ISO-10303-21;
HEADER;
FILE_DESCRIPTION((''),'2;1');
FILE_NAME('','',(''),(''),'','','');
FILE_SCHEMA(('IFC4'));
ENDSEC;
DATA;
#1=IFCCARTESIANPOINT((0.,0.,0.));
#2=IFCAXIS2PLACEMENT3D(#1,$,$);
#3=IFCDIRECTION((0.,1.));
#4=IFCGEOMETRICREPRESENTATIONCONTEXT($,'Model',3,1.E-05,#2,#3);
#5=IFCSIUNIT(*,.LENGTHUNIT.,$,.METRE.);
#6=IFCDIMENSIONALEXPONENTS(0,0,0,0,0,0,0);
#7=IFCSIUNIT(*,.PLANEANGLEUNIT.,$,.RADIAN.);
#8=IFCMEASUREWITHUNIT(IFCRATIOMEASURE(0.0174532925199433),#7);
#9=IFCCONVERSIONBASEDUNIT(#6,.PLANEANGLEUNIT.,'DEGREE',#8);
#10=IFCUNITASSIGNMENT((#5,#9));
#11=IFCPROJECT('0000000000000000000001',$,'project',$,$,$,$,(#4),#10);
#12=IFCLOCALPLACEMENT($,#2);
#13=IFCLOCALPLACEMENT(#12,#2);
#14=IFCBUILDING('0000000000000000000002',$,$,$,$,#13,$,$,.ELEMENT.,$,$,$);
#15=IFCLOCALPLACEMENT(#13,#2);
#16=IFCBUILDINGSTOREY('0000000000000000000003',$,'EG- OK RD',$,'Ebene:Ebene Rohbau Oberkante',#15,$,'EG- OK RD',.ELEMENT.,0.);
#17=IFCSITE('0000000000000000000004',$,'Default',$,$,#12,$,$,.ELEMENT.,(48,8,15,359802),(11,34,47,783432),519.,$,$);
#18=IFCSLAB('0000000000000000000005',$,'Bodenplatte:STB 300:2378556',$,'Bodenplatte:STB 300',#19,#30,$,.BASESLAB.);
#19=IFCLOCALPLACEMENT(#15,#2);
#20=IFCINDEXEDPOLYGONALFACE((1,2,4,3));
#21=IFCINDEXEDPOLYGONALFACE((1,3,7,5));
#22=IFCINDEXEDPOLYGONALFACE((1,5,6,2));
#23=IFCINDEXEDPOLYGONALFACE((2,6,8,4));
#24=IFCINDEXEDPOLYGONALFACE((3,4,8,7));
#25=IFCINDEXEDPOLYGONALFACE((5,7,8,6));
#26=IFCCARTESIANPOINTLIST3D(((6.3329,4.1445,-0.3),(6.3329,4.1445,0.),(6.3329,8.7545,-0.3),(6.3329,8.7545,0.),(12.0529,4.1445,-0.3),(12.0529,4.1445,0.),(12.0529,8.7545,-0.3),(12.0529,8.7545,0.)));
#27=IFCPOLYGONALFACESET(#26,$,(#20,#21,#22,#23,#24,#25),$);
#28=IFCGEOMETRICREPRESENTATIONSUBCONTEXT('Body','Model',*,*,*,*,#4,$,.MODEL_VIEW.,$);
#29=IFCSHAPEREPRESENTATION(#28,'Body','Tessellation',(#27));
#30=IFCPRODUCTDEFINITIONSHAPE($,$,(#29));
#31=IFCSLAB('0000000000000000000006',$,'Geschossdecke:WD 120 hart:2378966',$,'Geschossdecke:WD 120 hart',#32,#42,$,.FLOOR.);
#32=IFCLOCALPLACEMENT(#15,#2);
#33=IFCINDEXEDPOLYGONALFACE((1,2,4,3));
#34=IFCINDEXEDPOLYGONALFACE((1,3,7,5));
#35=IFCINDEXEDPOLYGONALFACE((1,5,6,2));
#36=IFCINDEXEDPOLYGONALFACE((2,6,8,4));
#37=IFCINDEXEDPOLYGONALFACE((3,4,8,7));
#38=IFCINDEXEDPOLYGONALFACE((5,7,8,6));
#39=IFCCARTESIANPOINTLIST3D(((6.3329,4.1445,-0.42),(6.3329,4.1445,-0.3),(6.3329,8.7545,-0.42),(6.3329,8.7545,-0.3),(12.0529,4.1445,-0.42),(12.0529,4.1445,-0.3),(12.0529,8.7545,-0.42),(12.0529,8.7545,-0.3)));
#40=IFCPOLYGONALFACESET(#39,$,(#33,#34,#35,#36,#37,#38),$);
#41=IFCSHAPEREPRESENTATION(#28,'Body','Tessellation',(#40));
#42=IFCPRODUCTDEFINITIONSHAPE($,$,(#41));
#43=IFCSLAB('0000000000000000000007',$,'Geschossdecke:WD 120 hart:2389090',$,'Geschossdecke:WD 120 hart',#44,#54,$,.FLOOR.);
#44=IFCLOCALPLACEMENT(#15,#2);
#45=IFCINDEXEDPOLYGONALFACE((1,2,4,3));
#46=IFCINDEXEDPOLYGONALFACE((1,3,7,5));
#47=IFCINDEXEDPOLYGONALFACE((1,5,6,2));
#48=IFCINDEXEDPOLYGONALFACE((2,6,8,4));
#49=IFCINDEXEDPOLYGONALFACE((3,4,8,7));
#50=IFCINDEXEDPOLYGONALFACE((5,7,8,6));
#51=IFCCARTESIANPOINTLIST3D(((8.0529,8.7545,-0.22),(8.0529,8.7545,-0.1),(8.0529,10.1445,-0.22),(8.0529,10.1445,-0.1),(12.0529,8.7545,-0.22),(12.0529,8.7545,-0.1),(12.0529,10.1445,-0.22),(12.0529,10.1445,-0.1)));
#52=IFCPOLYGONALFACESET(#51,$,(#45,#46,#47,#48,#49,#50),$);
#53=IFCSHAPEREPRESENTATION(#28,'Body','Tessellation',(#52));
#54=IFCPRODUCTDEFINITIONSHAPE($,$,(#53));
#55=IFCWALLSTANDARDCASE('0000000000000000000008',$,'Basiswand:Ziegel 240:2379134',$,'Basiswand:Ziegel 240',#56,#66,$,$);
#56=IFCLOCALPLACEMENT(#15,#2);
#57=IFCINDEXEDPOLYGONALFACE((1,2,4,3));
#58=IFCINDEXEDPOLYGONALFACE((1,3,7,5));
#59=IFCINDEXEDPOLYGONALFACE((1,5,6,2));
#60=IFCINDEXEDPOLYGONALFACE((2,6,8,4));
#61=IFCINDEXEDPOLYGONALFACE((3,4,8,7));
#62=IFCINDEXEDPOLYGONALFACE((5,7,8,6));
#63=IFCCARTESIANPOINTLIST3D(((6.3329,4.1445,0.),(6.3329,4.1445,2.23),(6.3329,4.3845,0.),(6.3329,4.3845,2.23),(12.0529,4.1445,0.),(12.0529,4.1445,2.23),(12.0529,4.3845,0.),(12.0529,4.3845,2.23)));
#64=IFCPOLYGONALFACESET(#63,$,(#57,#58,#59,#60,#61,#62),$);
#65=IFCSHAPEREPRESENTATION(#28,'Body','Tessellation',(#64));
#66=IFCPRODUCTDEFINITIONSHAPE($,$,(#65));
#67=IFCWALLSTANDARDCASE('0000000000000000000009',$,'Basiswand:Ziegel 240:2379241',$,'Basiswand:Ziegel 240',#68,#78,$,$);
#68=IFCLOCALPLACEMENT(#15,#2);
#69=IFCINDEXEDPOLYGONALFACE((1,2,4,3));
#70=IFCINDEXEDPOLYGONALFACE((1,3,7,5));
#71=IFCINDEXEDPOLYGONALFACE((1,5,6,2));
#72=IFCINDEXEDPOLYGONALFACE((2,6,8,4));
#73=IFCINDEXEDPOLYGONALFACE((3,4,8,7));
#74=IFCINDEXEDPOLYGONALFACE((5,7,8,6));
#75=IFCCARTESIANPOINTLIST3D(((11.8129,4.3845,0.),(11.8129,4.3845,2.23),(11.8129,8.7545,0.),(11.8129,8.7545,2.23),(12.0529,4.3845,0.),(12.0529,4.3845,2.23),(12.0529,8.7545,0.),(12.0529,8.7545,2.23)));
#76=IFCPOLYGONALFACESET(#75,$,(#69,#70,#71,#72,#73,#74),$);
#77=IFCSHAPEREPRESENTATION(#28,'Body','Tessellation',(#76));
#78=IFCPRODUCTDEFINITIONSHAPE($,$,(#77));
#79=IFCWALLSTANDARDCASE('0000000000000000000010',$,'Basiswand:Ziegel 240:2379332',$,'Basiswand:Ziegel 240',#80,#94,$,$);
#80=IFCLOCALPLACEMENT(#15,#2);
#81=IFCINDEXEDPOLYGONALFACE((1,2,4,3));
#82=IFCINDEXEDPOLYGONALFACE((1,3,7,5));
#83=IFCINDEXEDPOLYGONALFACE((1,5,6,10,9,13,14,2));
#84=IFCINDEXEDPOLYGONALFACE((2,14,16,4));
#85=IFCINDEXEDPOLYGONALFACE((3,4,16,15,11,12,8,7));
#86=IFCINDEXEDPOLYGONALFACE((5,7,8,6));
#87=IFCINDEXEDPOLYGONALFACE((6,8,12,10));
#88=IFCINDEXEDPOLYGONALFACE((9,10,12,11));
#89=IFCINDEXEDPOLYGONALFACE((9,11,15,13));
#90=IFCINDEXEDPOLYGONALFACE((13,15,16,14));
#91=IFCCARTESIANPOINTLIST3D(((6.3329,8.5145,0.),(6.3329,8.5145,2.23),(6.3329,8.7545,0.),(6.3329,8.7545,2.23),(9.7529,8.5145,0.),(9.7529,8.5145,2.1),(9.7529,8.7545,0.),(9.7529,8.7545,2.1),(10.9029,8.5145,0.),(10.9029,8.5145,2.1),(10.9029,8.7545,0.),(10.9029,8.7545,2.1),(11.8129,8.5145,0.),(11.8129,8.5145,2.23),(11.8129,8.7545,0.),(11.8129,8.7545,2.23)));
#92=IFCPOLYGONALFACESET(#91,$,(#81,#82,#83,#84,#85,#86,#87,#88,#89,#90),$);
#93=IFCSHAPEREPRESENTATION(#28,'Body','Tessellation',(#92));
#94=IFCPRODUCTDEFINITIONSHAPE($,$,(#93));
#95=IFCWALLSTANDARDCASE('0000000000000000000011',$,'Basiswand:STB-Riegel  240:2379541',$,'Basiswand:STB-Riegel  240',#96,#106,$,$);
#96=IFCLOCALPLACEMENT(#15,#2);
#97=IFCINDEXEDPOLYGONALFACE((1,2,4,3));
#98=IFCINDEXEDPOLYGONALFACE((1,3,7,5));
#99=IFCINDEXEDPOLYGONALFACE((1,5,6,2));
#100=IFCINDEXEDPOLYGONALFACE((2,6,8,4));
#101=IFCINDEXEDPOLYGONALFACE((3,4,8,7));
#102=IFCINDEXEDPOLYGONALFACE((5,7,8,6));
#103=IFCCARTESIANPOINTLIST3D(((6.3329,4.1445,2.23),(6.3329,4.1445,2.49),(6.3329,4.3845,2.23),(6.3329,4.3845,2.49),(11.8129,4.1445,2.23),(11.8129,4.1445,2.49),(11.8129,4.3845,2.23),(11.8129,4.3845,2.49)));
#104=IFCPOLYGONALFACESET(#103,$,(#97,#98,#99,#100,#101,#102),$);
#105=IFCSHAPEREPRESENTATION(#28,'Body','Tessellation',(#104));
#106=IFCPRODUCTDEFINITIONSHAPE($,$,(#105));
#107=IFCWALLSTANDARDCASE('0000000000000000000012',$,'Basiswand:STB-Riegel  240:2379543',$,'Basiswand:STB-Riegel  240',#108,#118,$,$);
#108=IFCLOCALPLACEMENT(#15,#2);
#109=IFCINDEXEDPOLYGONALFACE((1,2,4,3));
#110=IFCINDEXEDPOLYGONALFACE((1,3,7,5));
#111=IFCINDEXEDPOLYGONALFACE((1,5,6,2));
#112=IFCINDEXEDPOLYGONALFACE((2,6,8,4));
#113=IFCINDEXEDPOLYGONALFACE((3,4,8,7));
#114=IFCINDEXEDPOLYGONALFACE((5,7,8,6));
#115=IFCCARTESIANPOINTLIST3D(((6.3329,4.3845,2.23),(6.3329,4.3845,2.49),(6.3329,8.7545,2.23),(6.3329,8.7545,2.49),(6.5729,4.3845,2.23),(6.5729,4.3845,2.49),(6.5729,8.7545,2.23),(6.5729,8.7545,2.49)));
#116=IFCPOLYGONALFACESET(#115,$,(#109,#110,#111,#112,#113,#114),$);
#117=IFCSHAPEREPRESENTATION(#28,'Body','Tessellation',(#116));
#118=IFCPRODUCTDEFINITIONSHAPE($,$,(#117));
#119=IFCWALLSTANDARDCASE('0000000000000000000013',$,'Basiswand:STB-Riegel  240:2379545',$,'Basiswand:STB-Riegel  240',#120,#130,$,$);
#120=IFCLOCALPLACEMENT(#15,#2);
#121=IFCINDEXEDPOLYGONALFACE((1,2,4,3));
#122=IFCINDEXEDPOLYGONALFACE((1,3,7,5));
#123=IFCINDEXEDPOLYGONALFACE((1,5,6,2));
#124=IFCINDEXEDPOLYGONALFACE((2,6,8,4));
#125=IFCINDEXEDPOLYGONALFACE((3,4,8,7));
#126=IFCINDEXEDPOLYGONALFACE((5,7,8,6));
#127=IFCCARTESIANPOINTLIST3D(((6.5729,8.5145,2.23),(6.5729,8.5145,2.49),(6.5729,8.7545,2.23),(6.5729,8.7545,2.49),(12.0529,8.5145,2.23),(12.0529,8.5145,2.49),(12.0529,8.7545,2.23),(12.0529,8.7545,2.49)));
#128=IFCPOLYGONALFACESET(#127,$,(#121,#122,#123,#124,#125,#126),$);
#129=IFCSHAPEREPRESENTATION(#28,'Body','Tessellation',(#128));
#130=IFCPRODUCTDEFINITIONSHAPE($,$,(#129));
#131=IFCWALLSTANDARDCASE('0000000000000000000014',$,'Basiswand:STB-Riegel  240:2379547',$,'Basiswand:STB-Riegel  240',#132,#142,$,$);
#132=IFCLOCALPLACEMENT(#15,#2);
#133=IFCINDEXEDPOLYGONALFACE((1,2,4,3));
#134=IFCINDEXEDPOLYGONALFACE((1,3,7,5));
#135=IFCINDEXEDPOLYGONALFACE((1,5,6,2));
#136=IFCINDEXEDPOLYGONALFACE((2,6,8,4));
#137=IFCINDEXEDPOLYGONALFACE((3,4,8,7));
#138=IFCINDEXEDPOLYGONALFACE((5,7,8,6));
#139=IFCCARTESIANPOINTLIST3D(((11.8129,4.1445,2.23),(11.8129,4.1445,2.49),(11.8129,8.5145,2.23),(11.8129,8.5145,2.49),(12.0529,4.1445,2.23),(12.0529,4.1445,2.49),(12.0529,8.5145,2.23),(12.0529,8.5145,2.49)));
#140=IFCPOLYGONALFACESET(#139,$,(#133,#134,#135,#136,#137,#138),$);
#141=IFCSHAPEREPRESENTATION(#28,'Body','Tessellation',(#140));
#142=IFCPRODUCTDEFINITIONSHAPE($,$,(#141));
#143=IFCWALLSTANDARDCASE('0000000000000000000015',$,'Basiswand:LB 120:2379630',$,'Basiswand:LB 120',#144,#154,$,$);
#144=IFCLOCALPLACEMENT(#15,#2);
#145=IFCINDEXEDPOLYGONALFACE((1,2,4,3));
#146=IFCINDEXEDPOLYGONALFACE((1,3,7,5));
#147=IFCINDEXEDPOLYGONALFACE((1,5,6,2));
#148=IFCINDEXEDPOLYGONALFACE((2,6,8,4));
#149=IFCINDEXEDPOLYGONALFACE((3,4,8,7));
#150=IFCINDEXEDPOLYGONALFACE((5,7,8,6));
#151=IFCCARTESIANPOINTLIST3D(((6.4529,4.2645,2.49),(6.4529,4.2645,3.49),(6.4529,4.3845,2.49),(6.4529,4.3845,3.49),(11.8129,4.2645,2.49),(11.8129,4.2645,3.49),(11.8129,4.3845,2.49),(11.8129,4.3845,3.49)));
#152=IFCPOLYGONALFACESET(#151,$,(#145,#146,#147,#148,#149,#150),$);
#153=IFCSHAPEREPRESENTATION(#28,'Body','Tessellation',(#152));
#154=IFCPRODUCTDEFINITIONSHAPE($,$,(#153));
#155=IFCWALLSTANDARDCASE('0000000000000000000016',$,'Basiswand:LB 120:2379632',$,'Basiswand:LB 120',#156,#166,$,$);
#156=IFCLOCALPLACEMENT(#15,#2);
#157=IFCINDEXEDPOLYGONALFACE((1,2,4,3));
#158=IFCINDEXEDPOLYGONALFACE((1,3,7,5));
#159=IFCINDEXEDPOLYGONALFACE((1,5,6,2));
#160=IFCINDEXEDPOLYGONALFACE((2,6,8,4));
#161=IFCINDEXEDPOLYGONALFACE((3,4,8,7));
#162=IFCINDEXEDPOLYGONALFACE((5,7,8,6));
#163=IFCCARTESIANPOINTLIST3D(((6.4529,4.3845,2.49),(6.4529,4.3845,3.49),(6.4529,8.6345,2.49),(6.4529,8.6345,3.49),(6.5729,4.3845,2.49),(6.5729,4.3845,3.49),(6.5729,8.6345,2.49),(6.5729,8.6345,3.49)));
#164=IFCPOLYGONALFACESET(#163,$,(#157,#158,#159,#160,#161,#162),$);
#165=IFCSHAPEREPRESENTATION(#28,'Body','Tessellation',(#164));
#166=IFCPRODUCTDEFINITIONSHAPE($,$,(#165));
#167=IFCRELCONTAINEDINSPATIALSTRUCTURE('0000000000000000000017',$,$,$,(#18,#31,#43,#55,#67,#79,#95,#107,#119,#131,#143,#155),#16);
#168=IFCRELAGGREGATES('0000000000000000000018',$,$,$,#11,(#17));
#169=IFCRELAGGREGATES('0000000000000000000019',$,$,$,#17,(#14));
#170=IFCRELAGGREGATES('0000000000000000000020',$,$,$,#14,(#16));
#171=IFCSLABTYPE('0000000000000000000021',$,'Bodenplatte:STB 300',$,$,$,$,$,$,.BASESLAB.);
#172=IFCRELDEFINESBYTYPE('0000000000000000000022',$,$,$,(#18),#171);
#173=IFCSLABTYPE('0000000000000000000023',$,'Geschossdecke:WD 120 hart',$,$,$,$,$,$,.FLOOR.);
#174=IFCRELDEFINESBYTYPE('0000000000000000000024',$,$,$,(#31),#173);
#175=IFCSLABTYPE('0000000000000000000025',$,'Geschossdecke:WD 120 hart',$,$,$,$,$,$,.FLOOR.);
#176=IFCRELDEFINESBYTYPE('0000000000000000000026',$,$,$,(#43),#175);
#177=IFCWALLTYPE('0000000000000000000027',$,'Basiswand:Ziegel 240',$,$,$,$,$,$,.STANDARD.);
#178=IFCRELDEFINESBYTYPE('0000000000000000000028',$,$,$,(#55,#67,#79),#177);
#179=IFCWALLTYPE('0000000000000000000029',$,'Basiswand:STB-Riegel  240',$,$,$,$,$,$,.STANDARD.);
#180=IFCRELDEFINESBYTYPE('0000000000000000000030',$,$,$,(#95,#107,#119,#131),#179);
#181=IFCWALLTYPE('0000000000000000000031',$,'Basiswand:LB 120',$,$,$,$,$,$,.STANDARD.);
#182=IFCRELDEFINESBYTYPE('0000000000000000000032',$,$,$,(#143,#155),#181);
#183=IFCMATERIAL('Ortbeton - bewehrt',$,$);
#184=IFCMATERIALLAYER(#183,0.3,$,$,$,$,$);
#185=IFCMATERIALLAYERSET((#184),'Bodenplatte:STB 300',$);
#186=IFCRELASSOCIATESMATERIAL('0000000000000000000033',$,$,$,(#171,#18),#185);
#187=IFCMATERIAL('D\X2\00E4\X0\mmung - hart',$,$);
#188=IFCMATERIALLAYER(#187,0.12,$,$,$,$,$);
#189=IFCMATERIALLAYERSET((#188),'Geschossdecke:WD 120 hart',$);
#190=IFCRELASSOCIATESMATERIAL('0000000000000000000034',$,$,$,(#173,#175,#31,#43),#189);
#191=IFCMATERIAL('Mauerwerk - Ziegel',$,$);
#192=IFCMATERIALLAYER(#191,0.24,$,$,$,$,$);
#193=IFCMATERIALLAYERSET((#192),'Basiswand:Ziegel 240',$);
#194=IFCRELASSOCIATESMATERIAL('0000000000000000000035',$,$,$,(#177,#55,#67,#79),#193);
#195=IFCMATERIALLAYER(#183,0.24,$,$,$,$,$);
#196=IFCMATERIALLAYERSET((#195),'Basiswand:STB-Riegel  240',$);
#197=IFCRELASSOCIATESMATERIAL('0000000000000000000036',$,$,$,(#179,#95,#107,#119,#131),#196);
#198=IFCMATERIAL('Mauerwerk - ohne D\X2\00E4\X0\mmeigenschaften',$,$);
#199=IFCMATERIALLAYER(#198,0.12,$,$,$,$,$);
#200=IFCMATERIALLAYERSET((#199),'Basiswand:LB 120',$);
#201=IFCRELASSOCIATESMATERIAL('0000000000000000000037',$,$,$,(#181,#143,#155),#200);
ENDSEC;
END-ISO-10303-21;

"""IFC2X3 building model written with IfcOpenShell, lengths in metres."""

from ifc_helpers import new_model, entity, si_unit, converted_unit, direction, frame, frame_2d, origin, place, context, subcontext, project, spatial, rectangle, extrude, material, layer, layer_set, layer_usage, type_object, element, save


model = new_model("IFC2X3")

# Units and contexts
model_context = context("Model", 3, precision=1e-05, world=origin(), true_north=direction((0.0, 1.0)))
body_context = subcontext(model_context, "Body", "Model", "MODEL_VIEW")
ifc_project = project(units=[si_unit("LENGTHUNIT", "METRE"), converted_unit("PLANEANGLEUNIT", "DEGREE", entity("IfcRatioMeasure", 0.0174532925199433), si_unit("PLANEANGLEUNIT", "RADIAN"), dimensions=[0, 0, 0, 0, 0, 0, 0])], contexts=[model_context])

# Site, building, storey
site_placement = place(None, origin())
site = spatial("IfcSite", under=ifc_project, at=site_placement, Name="Default", CompositionType="ELEMENT", RefLatitude=(48, 8, 15, 359802), RefLongitude=(11, 34, 47, 783432), RefElevation=519.0)
building_placement = place(site_placement, origin())
building = spatial("IfcBuilding", under=site, at=building_placement, CompositionType="ELEMENT")
storey_placement = place(building_placement, origin())
storey = spatial("IfcBuildingStorey", under=building, at=storey_placement, Name="EG- OK RD", ObjectType="Ebene:Ebene Rohbau Oberkante", LongName="EG- OK RD", CompositionType="ELEMENT", Elevation=0.0)

# Slabs
ifc_material_1 = material(Name="Ortbeton - bewehrt")
ifc_layer_1 = layer(ifc_material_1, 0.3)
ifc_layer_set_1 = layer_set([ifc_layer_1], Name="Bodenplatte:STB 300")
ifc_layer_usage_1 = layer_usage(ifc_layer_set_1, "AXIS3", "POSITIVE", 0.0)
slab_type_1 = type_object("IfcSlabType", Name="Bodenplatte:STB 300", PredefinedType="BASESLAB", material=ifc_layer_set_1)
slab_1_placement = place(storey_placement, origin())
element("IfcSlab", 1, at=slab_1_placement, inside=storey, type_object=slab_type_1, material=ifc_layer_usage_1, Name="Bodenplatte:STB 300:2378556", ObjectType="Bodenplatte:STB 300", PredefinedType="BASESLAB", context=body_context, shape_type="SweptSolid", body=[
    extrude(rectangle(XDim=4.61, YDim=5.72, at=frame_2d((0.0, 0.0), x_axis=(1.0, 0.0))), frame((9.1929, 6.4495, 0.0), z_axis=(0.0, 0.0, -1.0), x_axis=(0.0, 1.0, 0.0)), (0.0, 0.0, 1.0), 0.3),
])
ifc_material_2 = material(Name="Dämmung - hart")
ifc_layer_2 = layer(ifc_material_2, 0.12)
ifc_layer_set_2 = layer_set([ifc_layer_2], Name="Geschossdecke:WD 120 hart")
ifc_layer_usage_2 = layer_usage(ifc_layer_set_2, "AXIS3", "POSITIVE", 0.0)
slab_type_2 = type_object("IfcSlabType", Name="Geschossdecke:WD 120 hart", PredefinedType="FLOOR", material=ifc_layer_set_2)
slab_2_placement = place(storey_placement, origin())
element("IfcSlab", 2, at=slab_2_placement, inside=storey, type_object=slab_type_2, material=ifc_layer_usage_2, Name="Geschossdecke:WD 120 hart:2378966", ObjectType="Geschossdecke:WD 120 hart", PredefinedType="FLOOR", context=body_context, shape_type="SweptSolid", body=[
    extrude(rectangle(XDim=4.61, YDim=5.72, at=frame_2d((0.0, 0.0), x_axis=(1.0, 0.0))), frame((9.1929, 6.4495, -0.3), z_axis=(0.0, 0.0, -1.0), x_axis=(0.0, 1.0, 0.0)), (0.0, 0.0, 1.0), 0.12),
])
ifc_layer_usage_3 = layer_usage(ifc_layer_set_2, "AXIS3", "POSITIVE", 0.0)
slab_type_3 = type_object("IfcSlabType", Name="Geschossdecke:WD 120 hart", PredefinedType="FLOOR", material=ifc_layer_set_2)
slab_3_placement = place(storey_placement, origin())
element("IfcSlab", 3, at=slab_3_placement, inside=storey, type_object=slab_type_3, material=ifc_layer_usage_3, Name="Geschossdecke:WD 120 hart:2389090", ObjectType="Geschossdecke:WD 120 hart", PredefinedType="FLOOR", context=body_context, shape_type="SweptSolid", body=[
    extrude(rectangle(XDim=1.39, YDim=4.0, at=frame_2d((0.0, 0.0), x_axis=(1.0, 0.0))), frame((10.0529, 9.4495, -0.1), z_axis=(0.0, 0.0, -1.0), x_axis=(0.0, 1.0, 0.0)), (0.0, 0.0, 1.0), 0.12),
])

# Walls
ifc_material_3 = material(Name="Mauerwerk - Ziegel")
ifc_layer_3 = layer(ifc_material_3, 0.24)
ifc_layer_set_3 = layer_set([ifc_layer_3], Name="Basiswand:Ziegel 240")
ifc_layer_usage_4 = layer_usage(ifc_layer_set_3, "AXIS2", "POSITIVE", -0.12)
wall_type_1 = type_object("IfcWallType", Name="Basiswand:Ziegel 240", PredefinedType="STANDARD", material=ifc_layer_set_3)
wall_1_placement = place(storey_placement, frame((6.3329, 4.2645, 0.0)))
element("IfcWallStandardCase", 4, at=wall_1_placement, inside=storey, type_object=wall_type_1, material=ifc_layer_usage_4, Name="Basiswand:Ziegel 240:2379134", ObjectType="Basiswand:Ziegel 240", context=body_context, shape_type="SweptSolid", body=[
    extrude(rectangle(XDim=5.72, YDim=0.24, at=frame_2d((2.86, 0.0), x_axis=(-1.0, 0.0))), origin(), (0.0, 0.0, 1.0), 2.23),
])
ifc_layer_usage_5 = layer_usage(ifc_layer_set_3, "AXIS2", "POSITIVE", -0.12)
wall_2_placement = place(storey_placement, frame((11.9329, 4.3845, 0.0), z_axis=(0.0, 0.0, 1.0), x_axis=(0.0, 1.0, 0.0)))
element("IfcWallStandardCase", 5, at=wall_2_placement, inside=storey, type_object=wall_type_1, material=ifc_layer_usage_5, Name="Basiswand:Ziegel 240:2379241", ObjectType="Basiswand:Ziegel 240", context=body_context, shape_type="SweptSolid", body=[
    extrude(rectangle(XDim=4.37, YDim=0.24, at=frame_2d((2.185, 0.0), x_axis=(-1.0, 0.0))), origin(), (0.0, 0.0, 1.0), 2.23),
])

# Wall, opening
ifc_layer_usage_6 = layer_usage(ifc_layer_set_3, "AXIS2", "POSITIVE", -0.12)
wall_3_placement = place(storey_placement, frame((11.8129, 8.6345, 0.0), z_axis=(0.0, 0.0, 1.0), x_axis=(-1.0, 0.0, 0.0)))
wall_3 = element("IfcWallStandardCase", 6, at=wall_3_placement, inside=storey, type_object=wall_type_1, material=ifc_layer_usage_6, Name="Basiswand:Ziegel 240:2379332", ObjectType="Basiswand:Ziegel 240", context=body_context, shape_type="SweptSolid", body=[
    extrude(rectangle(XDim=5.48, YDim=0.24, at=frame_2d((2.74, 0.0), x_axis=(-1.0, 0.0))), origin(), (0.0, 0.0, 1.0), 2.23),
])
opening_1_placement = place(wall_3_placement, frame((0.91, -0.12, 0.0)))
element("IfcOpeningElement", 7, at=opening_1_placement, cuts=wall_3, ObjectType="Opening", context=body_context, shape_type="SweptSolid", body=[
    extrude(rectangle(XDim=2.1, YDim=1.15, at=frame_2d((1.05, 0.575), x_axis=(-1.0, 0.0))), frame((0.0, 0.0, 0.0), z_axis=(0.0, 1.0, 0.0), x_axis=(0.0, 0.0, 1.0)), (0.0, 0.0, 1.0), 0.24),
])

# Walls
ifc_layer_4 = layer(ifc_material_1, 0.24)
ifc_layer_set_4 = layer_set([ifc_layer_4], Name="Basiswand:STB-Riegel  240")
ifc_layer_usage_7 = layer_usage(ifc_layer_set_4, "AXIS2", "NEGATIVE", 0.12)
wall_type_2 = type_object("IfcWallType", Name="Basiswand:STB-Riegel  240", PredefinedType="STANDARD", material=ifc_layer_set_4)
wall_4_placement = place(storey_placement, frame((6.3329, 4.2645, 2.23)))
element("IfcWallStandardCase", 8, at=wall_4_placement, inside=storey, type_object=wall_type_2, material=ifc_layer_usage_7, Name="Basiswand:STB-Riegel  240:2379541", ObjectType="Basiswand:STB-Riegel  240", context=body_context, shape_type="SweptSolid", body=[
    extrude(rectangle(XDim=5.48, YDim=0.24, at=frame_2d((2.74, 0.0), x_axis=(-1.0, 0.0))), origin(), (0.0, 0.0, 1.0), 0.26),
])
ifc_layer_usage_8 = layer_usage(ifc_layer_set_4, "AXIS2", "NEGATIVE", 0.12)
wall_5_placement = place(storey_placement, frame((6.4529, 8.7545, 2.23), z_axis=(0.0, 0.0, 1.0), x_axis=(0.0, -1.0, 0.0)))
element("IfcWallStandardCase", 9, at=wall_5_placement, inside=storey, type_object=wall_type_2, material=ifc_layer_usage_8, Name="Basiswand:STB-Riegel  240:2379543", ObjectType="Basiswand:STB-Riegel  240", context=body_context, shape_type="SweptSolid", body=[
    extrude(rectangle(XDim=4.37, YDim=0.24, at=frame_2d((2.185, 0.0), x_axis=(-1.0, 0.0))), origin(), (0.0, 0.0, 1.0), 0.26),
])
ifc_layer_usage_9 = layer_usage(ifc_layer_set_4, "AXIS2", "NEGATIVE", 0.12)
wall_6_placement = place(storey_placement, frame((12.0529, 8.6345, 2.23), z_axis=(0.0, 0.0, 1.0), x_axis=(-1.0, 0.0, 0.0)))
element("IfcWallStandardCase", 10, at=wall_6_placement, inside=storey, type_object=wall_type_2, material=ifc_layer_usage_9, Name="Basiswand:STB-Riegel  240:2379545", ObjectType="Basiswand:STB-Riegel  240", context=body_context, shape_type="SweptSolid", body=[
    extrude(rectangle(XDim=5.48, YDim=0.24, at=frame_2d((2.74, 0.0), x_axis=(-1.0, 0.0))), origin(), (0.0, 0.0, 1.0), 0.26),
])
ifc_layer_usage_10 = layer_usage(ifc_layer_set_4, "AXIS2", "NEGATIVE", 0.12)
wall_7_placement = place(storey_placement, frame((11.9329, 4.1445, 2.23), z_axis=(0.0, 0.0, 1.0), x_axis=(0.0, 1.0, 0.0)))
element("IfcWallStandardCase", 11, at=wall_7_placement, inside=storey, type_object=wall_type_2, material=ifc_layer_usage_10, Name="Basiswand:STB-Riegel  240:2379547", ObjectType="Basiswand:STB-Riegel  240", context=body_context, shape_type="SweptSolid", body=[
    extrude(rectangle(XDim=4.37, YDim=0.24, at=frame_2d((2.185, 0.0), x_axis=(-1.0, 0.0))), origin(), (0.0, 0.0, 1.0), 0.26),
])
ifc_material_4 = material(Name="Mauerwerk - ohne Dämmeigenschaften")
ifc_layer_5 = layer(ifc_material_4, 0.12)
ifc_layer_set_5 = layer_set([ifc_layer_5], Name="Basiswand:LB 120")
ifc_layer_usage_11 = layer_usage(ifc_layer_set_5, "AXIS2", "NEGATIVE", 0.06)
wall_type_3 = type_object("IfcWallType", Name="Basiswand:LB 120", PredefinedType="STANDARD", material=ifc_layer_set_5)
wall_8_placement = place(storey_placement, frame((6.4529, 4.3245, 2.49)))
element("IfcWallStandardCase", 12, at=wall_8_placement, inside=storey, type_object=wall_type_3, material=ifc_layer_usage_11, Name="Basiswand:LB 120:2379630", ObjectType="Basiswand:LB 120", context=body_context, shape_type="SweptSolid", body=[
    extrude(rectangle(XDim=5.36, YDim=0.12, at=frame_2d((2.68, 0.0), x_axis=(-1.0, 0.0))), origin(), (0.0, 0.0, 1.0), 1.0),
])
ifc_layer_usage_12 = layer_usage(ifc_layer_set_5, "AXIS2", "NEGATIVE", 0.06)
wall_9_placement = place(storey_placement, frame((6.5129, 8.6345, 2.49), z_axis=(0.0, 0.0, 1.0), x_axis=(0.0, -1.0, 0.0)))
element("IfcWallStandardCase", 13, at=wall_9_placement, inside=storey, type_object=wall_type_3, material=ifc_layer_usage_12, Name="Basiswand:LB 120:2379632", ObjectType="Basiswand:LB 120", context=body_context, shape_type="SweptSolid", body=[
    extrude(rectangle(XDim=4.25, YDim=0.12, at=frame_2d((2.125, 0.0), x_axis=(-1.0, 0.0))), origin(), (0.0, 0.0, 1.0), 1.0),
])

save(model, "model.ifc")
